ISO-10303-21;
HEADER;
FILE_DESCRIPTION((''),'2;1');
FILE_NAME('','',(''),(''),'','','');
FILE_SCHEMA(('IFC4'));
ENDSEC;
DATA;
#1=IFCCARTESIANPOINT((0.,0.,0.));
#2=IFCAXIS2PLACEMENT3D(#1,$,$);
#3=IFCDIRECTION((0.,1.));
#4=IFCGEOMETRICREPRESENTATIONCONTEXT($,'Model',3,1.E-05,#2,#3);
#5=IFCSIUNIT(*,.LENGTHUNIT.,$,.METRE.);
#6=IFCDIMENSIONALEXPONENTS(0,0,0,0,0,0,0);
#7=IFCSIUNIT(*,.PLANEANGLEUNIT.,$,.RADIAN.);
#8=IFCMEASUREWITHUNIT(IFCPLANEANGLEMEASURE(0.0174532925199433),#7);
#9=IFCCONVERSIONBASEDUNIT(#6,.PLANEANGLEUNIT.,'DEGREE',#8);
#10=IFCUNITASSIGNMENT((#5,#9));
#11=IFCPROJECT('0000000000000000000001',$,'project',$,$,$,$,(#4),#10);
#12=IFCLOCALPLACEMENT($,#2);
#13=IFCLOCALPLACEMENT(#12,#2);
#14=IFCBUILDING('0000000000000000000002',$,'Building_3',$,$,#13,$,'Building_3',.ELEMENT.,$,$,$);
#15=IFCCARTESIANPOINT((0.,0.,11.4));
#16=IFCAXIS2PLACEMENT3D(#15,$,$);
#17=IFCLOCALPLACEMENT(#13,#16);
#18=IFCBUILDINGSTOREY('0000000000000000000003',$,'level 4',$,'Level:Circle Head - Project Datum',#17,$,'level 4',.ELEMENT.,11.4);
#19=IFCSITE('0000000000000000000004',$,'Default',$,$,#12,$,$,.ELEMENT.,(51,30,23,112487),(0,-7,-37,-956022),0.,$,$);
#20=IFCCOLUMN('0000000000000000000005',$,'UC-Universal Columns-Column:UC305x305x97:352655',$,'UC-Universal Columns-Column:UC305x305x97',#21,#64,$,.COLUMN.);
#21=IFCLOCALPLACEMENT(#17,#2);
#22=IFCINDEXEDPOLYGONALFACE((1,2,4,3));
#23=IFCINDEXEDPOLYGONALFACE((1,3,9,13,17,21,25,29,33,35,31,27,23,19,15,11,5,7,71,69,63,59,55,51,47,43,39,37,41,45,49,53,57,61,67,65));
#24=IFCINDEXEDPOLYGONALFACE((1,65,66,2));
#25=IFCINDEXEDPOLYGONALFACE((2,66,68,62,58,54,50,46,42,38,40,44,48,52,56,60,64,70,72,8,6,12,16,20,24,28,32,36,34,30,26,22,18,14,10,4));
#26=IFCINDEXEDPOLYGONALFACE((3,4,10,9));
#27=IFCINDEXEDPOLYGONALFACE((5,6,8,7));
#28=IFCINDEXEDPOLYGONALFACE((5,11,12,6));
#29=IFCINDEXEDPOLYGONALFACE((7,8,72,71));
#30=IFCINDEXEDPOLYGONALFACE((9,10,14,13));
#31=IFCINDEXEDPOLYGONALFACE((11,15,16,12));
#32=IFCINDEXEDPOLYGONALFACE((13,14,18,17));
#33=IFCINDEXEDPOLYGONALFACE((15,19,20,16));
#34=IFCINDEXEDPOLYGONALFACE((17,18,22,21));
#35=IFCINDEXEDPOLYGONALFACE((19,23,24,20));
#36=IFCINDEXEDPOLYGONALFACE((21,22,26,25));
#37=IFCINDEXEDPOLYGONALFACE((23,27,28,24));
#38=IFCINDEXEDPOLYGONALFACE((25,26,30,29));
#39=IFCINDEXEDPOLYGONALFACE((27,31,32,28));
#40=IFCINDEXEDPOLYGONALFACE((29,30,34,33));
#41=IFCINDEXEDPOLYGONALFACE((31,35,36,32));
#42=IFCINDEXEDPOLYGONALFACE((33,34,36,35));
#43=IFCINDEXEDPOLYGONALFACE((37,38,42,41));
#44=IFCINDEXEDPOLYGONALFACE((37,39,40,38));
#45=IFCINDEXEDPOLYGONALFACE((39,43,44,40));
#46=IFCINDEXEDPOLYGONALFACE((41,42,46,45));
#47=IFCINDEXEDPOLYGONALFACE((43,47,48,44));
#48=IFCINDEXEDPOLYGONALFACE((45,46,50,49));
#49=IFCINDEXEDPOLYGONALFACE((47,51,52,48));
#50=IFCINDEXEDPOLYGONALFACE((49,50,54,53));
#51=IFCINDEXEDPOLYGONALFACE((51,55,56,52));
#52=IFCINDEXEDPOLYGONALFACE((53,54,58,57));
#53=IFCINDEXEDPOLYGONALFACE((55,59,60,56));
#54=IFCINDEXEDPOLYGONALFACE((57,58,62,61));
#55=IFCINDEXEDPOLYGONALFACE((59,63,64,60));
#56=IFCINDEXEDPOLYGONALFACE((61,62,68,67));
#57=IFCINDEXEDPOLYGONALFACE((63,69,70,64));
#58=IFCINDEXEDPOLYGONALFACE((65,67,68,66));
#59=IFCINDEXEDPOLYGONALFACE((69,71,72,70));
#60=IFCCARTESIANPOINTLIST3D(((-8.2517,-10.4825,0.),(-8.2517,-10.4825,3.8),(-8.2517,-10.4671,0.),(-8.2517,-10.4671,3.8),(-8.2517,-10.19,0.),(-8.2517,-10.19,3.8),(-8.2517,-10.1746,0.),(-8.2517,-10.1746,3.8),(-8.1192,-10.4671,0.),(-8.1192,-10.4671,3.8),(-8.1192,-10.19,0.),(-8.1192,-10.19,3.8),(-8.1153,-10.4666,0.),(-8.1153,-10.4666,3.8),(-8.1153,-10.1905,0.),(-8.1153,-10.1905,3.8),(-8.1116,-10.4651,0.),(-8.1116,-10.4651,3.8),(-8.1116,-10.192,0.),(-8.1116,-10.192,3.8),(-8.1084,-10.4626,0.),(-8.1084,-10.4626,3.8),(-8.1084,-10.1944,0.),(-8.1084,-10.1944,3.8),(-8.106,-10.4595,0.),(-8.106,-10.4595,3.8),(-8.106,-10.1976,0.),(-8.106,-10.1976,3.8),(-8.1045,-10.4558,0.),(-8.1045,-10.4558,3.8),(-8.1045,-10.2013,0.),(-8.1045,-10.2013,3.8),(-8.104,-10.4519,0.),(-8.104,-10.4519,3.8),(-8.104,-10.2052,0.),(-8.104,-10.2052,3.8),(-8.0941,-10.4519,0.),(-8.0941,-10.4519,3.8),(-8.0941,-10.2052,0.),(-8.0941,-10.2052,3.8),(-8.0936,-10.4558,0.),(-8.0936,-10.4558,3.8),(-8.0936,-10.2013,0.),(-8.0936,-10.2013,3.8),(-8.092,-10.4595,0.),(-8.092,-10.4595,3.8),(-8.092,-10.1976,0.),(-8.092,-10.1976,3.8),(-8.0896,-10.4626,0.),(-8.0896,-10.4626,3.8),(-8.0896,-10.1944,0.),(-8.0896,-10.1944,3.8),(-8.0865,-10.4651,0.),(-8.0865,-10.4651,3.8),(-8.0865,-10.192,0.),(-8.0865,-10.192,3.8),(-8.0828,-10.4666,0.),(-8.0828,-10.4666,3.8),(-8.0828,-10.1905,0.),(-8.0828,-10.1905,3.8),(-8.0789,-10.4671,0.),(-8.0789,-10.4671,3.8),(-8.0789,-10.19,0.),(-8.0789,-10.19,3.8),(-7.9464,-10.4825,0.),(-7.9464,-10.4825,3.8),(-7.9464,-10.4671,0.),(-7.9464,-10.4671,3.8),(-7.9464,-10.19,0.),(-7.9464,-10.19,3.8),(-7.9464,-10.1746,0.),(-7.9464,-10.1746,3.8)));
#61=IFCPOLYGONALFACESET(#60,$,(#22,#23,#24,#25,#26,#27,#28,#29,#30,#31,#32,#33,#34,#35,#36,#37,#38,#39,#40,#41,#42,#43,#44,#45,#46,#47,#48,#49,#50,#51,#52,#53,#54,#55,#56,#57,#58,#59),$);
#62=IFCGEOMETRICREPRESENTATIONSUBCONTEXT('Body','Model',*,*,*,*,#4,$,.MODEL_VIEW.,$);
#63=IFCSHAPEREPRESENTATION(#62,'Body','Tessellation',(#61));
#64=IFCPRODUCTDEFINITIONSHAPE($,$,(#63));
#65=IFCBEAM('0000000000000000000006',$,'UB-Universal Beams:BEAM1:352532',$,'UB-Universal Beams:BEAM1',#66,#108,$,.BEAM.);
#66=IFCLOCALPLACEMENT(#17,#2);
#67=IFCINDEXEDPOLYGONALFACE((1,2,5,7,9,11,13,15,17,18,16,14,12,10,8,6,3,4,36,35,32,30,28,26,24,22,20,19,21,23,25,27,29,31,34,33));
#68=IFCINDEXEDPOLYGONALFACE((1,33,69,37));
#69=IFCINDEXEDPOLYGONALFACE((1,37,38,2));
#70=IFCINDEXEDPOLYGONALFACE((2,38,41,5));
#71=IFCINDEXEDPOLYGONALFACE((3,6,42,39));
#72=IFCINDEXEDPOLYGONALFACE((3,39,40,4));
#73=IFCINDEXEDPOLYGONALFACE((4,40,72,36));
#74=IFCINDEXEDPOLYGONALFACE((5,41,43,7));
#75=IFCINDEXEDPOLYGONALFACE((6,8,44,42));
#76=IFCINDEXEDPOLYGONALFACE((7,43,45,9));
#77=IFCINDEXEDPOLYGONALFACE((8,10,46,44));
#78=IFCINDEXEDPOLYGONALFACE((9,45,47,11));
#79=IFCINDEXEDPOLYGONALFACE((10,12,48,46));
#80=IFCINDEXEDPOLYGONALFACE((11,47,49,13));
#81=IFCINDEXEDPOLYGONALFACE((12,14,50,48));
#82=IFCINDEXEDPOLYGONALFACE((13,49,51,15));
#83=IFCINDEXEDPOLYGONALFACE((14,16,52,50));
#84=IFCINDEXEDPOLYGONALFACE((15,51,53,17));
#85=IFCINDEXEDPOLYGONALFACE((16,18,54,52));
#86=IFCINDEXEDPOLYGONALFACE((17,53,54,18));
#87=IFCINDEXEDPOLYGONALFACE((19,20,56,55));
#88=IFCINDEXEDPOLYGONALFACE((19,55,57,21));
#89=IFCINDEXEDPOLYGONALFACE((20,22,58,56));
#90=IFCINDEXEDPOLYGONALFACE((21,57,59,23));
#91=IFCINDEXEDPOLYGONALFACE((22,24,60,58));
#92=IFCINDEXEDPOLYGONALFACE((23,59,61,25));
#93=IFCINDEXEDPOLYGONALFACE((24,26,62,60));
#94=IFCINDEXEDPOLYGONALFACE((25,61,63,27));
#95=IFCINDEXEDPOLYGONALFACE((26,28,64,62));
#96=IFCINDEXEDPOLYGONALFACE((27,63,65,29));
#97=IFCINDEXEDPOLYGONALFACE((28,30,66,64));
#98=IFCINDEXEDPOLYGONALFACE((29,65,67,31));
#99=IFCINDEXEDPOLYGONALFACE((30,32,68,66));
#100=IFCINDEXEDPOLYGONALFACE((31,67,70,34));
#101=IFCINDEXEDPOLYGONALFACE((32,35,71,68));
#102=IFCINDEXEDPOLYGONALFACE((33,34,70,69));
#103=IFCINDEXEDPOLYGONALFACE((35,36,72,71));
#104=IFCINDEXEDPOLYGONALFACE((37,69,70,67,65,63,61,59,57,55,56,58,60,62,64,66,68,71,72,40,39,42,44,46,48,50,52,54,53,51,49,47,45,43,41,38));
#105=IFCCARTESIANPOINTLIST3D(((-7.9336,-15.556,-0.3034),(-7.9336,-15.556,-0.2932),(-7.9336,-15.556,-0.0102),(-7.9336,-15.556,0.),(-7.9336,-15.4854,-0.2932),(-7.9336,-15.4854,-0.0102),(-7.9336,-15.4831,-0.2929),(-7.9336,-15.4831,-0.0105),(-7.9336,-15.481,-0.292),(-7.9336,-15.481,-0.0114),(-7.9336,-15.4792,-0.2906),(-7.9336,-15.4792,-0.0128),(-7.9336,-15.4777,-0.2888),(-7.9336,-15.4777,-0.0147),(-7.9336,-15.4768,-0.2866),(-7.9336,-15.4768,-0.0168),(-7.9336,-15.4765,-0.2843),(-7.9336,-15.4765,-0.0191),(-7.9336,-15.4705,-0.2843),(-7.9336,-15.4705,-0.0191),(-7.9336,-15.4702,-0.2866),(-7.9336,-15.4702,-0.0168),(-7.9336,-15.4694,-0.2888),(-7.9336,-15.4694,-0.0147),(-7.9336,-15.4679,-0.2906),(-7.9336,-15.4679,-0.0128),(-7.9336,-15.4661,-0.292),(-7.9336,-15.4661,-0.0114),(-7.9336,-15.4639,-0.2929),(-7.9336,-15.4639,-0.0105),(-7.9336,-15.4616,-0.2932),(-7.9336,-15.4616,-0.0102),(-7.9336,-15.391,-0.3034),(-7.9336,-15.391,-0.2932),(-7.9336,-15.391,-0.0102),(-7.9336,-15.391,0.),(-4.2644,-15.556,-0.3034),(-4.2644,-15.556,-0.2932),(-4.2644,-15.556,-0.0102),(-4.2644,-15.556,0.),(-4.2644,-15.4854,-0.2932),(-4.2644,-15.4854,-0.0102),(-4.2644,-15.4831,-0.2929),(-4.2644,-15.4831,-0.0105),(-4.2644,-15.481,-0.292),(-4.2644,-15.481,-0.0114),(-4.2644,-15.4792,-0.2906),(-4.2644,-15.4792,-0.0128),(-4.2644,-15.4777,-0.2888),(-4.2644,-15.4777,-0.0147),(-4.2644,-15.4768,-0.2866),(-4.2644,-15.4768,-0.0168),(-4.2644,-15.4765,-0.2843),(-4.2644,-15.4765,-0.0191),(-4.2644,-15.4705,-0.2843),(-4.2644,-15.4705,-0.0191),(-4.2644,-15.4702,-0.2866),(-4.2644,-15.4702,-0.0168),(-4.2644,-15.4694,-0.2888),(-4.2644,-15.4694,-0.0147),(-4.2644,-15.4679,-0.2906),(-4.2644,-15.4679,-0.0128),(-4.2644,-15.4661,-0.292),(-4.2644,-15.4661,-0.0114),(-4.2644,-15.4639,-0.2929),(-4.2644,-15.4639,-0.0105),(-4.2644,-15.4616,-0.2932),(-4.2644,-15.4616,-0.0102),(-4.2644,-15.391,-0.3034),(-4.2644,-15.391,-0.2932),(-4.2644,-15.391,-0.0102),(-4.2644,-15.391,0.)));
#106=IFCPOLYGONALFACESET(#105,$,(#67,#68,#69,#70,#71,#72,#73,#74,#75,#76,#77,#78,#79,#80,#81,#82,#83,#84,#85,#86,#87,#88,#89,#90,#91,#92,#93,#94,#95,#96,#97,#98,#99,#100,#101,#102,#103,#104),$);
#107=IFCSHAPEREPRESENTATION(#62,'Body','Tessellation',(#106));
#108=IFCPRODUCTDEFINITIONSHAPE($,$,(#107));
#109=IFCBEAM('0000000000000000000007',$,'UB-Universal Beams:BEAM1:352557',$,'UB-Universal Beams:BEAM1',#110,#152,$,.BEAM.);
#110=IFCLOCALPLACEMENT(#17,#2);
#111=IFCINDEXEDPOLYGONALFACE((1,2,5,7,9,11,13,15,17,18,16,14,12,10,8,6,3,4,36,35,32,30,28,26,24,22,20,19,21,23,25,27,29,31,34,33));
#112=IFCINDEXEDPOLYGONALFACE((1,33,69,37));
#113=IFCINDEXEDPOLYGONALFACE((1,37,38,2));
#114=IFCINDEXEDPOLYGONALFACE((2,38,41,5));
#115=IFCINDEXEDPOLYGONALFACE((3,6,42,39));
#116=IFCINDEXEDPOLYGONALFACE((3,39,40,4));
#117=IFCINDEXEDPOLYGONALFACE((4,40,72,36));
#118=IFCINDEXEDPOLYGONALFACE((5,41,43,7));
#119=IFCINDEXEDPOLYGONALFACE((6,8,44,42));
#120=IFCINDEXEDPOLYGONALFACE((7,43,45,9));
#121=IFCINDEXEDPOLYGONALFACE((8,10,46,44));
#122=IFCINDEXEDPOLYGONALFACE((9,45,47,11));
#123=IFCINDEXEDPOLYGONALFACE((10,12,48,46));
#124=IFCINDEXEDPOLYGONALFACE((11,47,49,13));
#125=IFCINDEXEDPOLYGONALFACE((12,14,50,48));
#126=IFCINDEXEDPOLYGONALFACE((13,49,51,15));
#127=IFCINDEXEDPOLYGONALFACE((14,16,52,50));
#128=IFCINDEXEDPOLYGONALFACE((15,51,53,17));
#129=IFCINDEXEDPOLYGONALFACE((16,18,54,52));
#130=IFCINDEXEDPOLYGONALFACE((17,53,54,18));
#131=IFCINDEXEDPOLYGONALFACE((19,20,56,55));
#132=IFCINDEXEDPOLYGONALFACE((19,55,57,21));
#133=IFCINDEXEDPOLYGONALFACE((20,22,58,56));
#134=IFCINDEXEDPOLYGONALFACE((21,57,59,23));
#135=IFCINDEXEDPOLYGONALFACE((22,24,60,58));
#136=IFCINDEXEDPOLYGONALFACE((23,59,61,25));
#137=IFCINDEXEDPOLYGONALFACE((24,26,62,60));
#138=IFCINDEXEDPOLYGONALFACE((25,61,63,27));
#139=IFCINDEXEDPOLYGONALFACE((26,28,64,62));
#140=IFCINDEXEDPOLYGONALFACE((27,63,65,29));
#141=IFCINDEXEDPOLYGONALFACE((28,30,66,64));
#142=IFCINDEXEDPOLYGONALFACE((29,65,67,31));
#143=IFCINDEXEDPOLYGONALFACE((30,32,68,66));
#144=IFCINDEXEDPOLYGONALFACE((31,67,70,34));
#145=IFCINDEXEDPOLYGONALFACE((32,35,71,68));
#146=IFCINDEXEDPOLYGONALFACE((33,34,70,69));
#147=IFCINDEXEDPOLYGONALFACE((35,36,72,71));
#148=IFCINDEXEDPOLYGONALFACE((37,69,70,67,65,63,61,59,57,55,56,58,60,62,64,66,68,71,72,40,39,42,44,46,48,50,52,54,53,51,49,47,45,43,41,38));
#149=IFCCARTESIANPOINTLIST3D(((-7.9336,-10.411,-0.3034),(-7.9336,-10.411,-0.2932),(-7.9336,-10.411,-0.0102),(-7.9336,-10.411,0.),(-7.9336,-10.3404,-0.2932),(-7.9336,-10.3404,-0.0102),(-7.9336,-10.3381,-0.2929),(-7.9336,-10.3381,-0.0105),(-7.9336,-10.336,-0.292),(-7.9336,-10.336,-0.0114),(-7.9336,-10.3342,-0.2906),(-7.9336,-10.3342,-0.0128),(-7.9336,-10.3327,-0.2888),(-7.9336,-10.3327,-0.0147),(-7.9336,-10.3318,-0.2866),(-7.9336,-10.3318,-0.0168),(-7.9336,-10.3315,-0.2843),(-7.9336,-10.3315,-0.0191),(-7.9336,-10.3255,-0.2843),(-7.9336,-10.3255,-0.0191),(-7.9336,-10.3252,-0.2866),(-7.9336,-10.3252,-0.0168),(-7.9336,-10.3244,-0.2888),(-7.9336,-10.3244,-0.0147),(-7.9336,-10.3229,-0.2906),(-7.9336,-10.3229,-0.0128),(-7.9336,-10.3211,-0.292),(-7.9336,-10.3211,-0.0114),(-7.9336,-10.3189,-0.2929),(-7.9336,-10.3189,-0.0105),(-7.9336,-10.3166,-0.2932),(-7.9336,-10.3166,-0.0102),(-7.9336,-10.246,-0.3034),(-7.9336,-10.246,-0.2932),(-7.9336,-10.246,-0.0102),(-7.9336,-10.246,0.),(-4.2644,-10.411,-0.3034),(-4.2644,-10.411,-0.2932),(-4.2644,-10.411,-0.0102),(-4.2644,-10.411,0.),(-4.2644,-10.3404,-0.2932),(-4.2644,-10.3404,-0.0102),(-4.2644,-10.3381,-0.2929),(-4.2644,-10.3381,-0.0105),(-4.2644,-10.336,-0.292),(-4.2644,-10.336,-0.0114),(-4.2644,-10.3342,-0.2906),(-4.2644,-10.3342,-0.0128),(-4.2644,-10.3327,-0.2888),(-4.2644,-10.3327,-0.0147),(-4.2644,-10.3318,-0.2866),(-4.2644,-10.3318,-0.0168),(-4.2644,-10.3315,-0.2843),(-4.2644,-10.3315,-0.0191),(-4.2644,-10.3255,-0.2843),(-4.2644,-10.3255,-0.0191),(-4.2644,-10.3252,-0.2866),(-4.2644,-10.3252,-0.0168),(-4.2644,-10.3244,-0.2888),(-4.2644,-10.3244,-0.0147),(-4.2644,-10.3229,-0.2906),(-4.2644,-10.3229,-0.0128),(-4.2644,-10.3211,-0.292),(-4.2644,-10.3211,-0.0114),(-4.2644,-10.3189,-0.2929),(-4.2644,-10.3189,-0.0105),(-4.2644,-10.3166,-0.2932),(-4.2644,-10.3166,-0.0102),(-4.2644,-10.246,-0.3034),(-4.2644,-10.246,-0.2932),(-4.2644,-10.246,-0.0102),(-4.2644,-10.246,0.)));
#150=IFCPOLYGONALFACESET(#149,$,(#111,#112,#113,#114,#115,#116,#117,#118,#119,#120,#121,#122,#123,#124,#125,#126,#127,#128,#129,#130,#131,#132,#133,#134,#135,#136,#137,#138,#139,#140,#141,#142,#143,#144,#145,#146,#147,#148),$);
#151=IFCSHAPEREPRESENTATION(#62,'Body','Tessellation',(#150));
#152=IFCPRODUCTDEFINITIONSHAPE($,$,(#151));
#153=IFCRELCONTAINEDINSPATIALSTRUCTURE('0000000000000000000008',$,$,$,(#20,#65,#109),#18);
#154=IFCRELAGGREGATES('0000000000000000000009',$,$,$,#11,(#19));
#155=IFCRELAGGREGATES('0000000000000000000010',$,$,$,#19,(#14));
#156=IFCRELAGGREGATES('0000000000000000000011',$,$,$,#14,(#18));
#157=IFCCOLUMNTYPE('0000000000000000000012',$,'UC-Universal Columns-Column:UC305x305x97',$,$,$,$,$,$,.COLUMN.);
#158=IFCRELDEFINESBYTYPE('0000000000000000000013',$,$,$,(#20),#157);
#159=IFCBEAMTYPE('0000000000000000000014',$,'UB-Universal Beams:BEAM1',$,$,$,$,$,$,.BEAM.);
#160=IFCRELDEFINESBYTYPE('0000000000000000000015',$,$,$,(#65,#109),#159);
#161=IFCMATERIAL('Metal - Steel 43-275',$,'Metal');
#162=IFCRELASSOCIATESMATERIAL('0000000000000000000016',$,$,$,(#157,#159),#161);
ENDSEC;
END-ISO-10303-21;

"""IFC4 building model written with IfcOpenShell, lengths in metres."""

from ifc_helpers import new_model, entity, si_unit, converted_unit, direction, frame, frame_2d, origin, origin_2d_with_axis, place, context, subcontext, project, spatial, polyline, circle_curve, parameter, trimmed, segment, composite_curve, i_section, outline, extrude, source, transform, mapped, material, material_profile, profile_set, type_object, type_shapes, element, save


model = new_model("IFC4")

# Units and contexts
model_context = context("Model", 3, precision=1e-05, world=origin(), true_north=direction((0.0, 1.0)))
body_context = subcontext(model_context, "Body", "Model", "MODEL_VIEW")
ifc_project = project(units=[si_unit("LENGTHUNIT", "METRE"), converted_unit("PLANEANGLEUNIT", "DEGREE", entity("IfcPlaneAngleMeasure", 0.0174532925199433), si_unit("PLANEANGLEUNIT", "RADIAN"), dimensions=[0, 0, 0, 0, 0, 0, 0])], contexts=[model_context])

# Site, building, storey
site_placement = place(None, origin())
site = spatial("IfcSite", under=ifc_project, at=site_placement, Name="Default", CompositionType="ELEMENT", RefLatitude=(51, 30, 23, 112487), RefLongitude=(0, -7, -37, -956022), RefElevation=0.0)
building_placement = place(site_placement, origin())
building = spatial("IfcBuilding", under=site, at=building_placement, Name="Building_3", LongName="Building_3", CompositionType="ELEMENT")
storey_placement = place(building_placement, frame((0.0, 0.0, 11.4)))
storey = spatial("IfcBuildingStorey", under=building, at=storey_placement, Name="level 4", ObjectType="Level:Circle Head - Project Datum", LongName="level 4", CompositionType="ELEMENT", Elevation=11.4)

# Column
ifc_material_1 = material(Name="Metal - Steel 43-275", Category="Metal")
ifc_material_profile_1 = material_profile(ifc_material_1, i_section(OverallWidth=0.3053, OverallDepth=0.3079, WebThickness=0.0099, FlangeThickness=0.0154, FilletRadius=0.0152, at=frame_2d((0.0, 0.0), x_axis=(1.0, 0.0))), Name="UC305x305x97")
ifc_profile_set_1 = profile_set([ifc_material_profile_1], Name="UC305x305x97")
column_type = type_object("IfcColumnType", Name="UC-Universal Columns-Column:UC305x305x97", PredefinedType="COLUMN", material=ifc_profile_set_1)
shared_shape_1 = source(origin(), body_context, "Body", "SweptSolid", [
    extrude(i_section(OverallWidth=0.3053, OverallDepth=0.3079, WebThickness=0.0099, FlangeThickness=0.0154, FilletRadius=0.0152, at=origin_2d_with_axis()), frame((0.0, 0.0, 11.4), z_axis=(0.0, 0.0, 1.0), x_axis=(-1.0, 0.0, 0.0)), (0.0, 0.0, 1.0), 3.8),
])
type_shapes(column_type, [shared_shape_1])
column_placement = place(storey_placement, frame((-8.099, -10.3285, -11.4)))
element("IfcColumn", 1, at=column_placement, inside=storey, type_object=column_type, Name="UC-Universal Columns-Column:UC305x305x97:352655", ObjectType="UC-Universal Columns-Column:UC305x305x97", PredefinedType="COLUMN", context=body_context, shape_type="MappedRepresentation", body=[
    mapped(shared_shape_1, transform((0.0, 0.0, 0.0), scale=1.0)),
])

# Beams
ifc_material_profile_2 = material_profile(ifc_material_1, outline(composite_curve([segment(polyline([(-0.0825, -0.1415), (-0.0825, -0.1517)]), True, "CONTINUOUS"), segment(polyline([(-0.0825, -0.1517), (0.0825, -0.1517)]), True, "CONTINUOUS"), segment(polyline([(0.0825, -0.1517), (0.0825, -0.1415)]), True, "CONTINUOUS"), segment(polyline([(0.0825, -0.1415), (0.0119, -0.1415)]), True, "CONTINUOUS"), segment(trimmed(circle_curve(frame_2d((0.0119, -0.1326), x_axis=(1.0, 0.0)), 0.0089), [parameter(180.0)], [parameter(270.0)], True, "PARAMETER"), False, "CONTINUOUS"), segment(polyline([(0.003, -0.1326), (0.003, 0.1326)]), True, "CONTINUOUS"), segment(trimmed(circle_curve(frame_2d((0.0119, 0.1326), x_axis=(1.0, 0.0)), 0.0089), [parameter(90.0)], [parameter(180.0)], True, "PARAMETER"), False, "CONTINUOUS"), segment(polyline([(0.0119, 0.1415), (0.0825, 0.1415)]), True, "CONTINUOUS"), segment(polyline([(0.0825, 0.1415), (0.0825, 0.1517)]), True, "CONTINUOUS"), segment(polyline([(0.0825, 0.1517), (-0.0825, 0.1517)]), True, "CONTINUOUS"), segment(polyline([(-0.0825, 0.1517), (-0.0825, 0.1415)]), True, "CONTINUOUS"), segment(polyline([(-0.0825, 0.1415), (-0.0119, 0.1415)]), True, "CONTINUOUS"), segment(trimmed(circle_curve(frame_2d((-0.0119, 0.1326), x_axis=(1.0, 0.0)), 0.0089), [parameter(360.0)], [parameter(90.0)], True, "PARAMETER"), False, "CONTINUOUS"), segment(polyline([(-0.003, 0.1326), (-0.003, -0.1326)]), True, "CONTINUOUS"), segment(trimmed(circle_curve(frame_2d((-0.0119, -0.1326), x_axis=(1.0, 0.0)), 0.0089), [parameter(270.0)], [parameter(360.0)], True, "PARAMETER"), False, "CONTINUOUS"), segment(polyline([(-0.0119, -0.1415), (-0.0825, -0.1415)]), True, "CONTINUOUS")], self_intersect=False)), Name="BEAM1")
ifc_profile_set_2 = profile_set([ifc_material_profile_2], Name="BEAM1")
beam_type_1 = type_object("IfcBeamType", Name="UB-Universal Beams:BEAM1", PredefinedType="BEAM", material=ifc_profile_set_2)
shared_shape_2 = source(origin(), body_context, "Body", "SweptSolid", [
    extrude(outline(composite_curve([segment(polyline([(-0.0825, -0.1415), (-0.0825, -0.1517)]), True, "CONTINUOUS"), segment(polyline([(-0.0825, -0.1517), (0.0825, -0.1517)]), True, "CONTINUOUS"), segment(polyline([(0.0825, -0.1517), (0.0825, -0.1415)]), True, "CONTINUOUS"), segment(polyline([(0.0825, -0.1415), (0.0119, -0.1415)]), True, "CONTINUOUS"), segment(trimmed(circle_curve(frame_2d((0.0119, -0.1326), x_axis=(0.0, -1.0)), 0.0089), [parameter(270.0)], [parameter(360.0)], True, "PARAMETER"), False, "CONTINUOUS"), segment(polyline([(0.003, -0.1326), (0.003, 0.1326)]), True, "CONTINUOUS"), segment(trimmed(circle_curve(frame_2d((0.0119, 0.1326), x_axis=(-1.0, 0.0)), 0.0089), [parameter(270.0)], [parameter(360.0)], True, "PARAMETER"), False, "CONTINUOUS"), segment(polyline([(0.0119, 0.1415), (0.0825, 0.1415)]), True, "CONTINUOUS"), segment(polyline([(0.0825, 0.1415), (0.0825, 0.1517)]), True, "CONTINUOUS"), segment(polyline([(0.0825, 0.1517), (-0.0825, 0.1517)]), True, "CONTINUOUS"), segment(polyline([(-0.0825, 0.1517), (-0.0825, 0.1415)]), True, "CONTINUOUS"), segment(polyline([(-0.0825, 0.1415), (-0.0119, 0.1415)]), True, "CONTINUOUS"), segment(trimmed(circle_curve(frame_2d((-0.0119, 0.1326), x_axis=(0.0, 1.0)), 0.0089), [parameter(270.0)], [parameter(360.0)], True, "PARAMETER"), False, "CONTINUOUS"), segment(polyline([(-0.003, 0.1326), (-0.003, -0.1326)]), True, "CONTINUOUS"), segment(trimmed(circle_curve(frame_2d((-0.0119, -0.1326), x_axis=(1.0, 0.0)), 0.0089), [parameter(270.0)], [parameter(0.0)], True, "PARAMETER"), False, "CONTINUOUS"), segment(polyline([(-0.0119, -0.1415), (-0.0825, -0.1415)]), True, "CONTINUOUS")], self_intersect=False)), frame((-1.8346, 0.0, 0.0), z_axis=(-1.0, 0.0, 0.0), x_axis=(0.0, -1.0, 0.0)), (0.0, 0.0, -1.0), 3.6692),
])
type_shapes(beam_type_1, [shared_shape_2])
beam_1_placement = place(storey_placement, frame((-6.099, -15.4735, -0.1517), z_axis=(0.0, 0.0, 1.0), x_axis=(-1.0, 0.0, 0.0)))
element("IfcBeam", 2, at=beam_1_placement, inside=storey, type_object=beam_type_1, Name="UB-Universal Beams:BEAM1:352532", ObjectType="UB-Universal Beams:BEAM1", PredefinedType="BEAM", context=body_context, shape_type="MappedRepresentation", body=[
    mapped(shared_shape_2, transform((0.0, 0.0, 0.0), scale=1.0)),
])
beam_2_placement = place(storey_placement, frame((-6.099, -10.3285, -0.1517)))
element("IfcBeam", 3, at=beam_2_placement, inside=storey, type_object=beam_type_1, Name="UB-Universal Beams:BEAM1:352557", ObjectType="UB-Universal Beams:BEAM1", PredefinedType="BEAM", context=body_context, shape_type="MappedRepresentation", body=[
    mapped(shared_shape_2, transform((0.0, 0.0, 0.0), scale=1.0)),
])

save(model, "model.ifc")
